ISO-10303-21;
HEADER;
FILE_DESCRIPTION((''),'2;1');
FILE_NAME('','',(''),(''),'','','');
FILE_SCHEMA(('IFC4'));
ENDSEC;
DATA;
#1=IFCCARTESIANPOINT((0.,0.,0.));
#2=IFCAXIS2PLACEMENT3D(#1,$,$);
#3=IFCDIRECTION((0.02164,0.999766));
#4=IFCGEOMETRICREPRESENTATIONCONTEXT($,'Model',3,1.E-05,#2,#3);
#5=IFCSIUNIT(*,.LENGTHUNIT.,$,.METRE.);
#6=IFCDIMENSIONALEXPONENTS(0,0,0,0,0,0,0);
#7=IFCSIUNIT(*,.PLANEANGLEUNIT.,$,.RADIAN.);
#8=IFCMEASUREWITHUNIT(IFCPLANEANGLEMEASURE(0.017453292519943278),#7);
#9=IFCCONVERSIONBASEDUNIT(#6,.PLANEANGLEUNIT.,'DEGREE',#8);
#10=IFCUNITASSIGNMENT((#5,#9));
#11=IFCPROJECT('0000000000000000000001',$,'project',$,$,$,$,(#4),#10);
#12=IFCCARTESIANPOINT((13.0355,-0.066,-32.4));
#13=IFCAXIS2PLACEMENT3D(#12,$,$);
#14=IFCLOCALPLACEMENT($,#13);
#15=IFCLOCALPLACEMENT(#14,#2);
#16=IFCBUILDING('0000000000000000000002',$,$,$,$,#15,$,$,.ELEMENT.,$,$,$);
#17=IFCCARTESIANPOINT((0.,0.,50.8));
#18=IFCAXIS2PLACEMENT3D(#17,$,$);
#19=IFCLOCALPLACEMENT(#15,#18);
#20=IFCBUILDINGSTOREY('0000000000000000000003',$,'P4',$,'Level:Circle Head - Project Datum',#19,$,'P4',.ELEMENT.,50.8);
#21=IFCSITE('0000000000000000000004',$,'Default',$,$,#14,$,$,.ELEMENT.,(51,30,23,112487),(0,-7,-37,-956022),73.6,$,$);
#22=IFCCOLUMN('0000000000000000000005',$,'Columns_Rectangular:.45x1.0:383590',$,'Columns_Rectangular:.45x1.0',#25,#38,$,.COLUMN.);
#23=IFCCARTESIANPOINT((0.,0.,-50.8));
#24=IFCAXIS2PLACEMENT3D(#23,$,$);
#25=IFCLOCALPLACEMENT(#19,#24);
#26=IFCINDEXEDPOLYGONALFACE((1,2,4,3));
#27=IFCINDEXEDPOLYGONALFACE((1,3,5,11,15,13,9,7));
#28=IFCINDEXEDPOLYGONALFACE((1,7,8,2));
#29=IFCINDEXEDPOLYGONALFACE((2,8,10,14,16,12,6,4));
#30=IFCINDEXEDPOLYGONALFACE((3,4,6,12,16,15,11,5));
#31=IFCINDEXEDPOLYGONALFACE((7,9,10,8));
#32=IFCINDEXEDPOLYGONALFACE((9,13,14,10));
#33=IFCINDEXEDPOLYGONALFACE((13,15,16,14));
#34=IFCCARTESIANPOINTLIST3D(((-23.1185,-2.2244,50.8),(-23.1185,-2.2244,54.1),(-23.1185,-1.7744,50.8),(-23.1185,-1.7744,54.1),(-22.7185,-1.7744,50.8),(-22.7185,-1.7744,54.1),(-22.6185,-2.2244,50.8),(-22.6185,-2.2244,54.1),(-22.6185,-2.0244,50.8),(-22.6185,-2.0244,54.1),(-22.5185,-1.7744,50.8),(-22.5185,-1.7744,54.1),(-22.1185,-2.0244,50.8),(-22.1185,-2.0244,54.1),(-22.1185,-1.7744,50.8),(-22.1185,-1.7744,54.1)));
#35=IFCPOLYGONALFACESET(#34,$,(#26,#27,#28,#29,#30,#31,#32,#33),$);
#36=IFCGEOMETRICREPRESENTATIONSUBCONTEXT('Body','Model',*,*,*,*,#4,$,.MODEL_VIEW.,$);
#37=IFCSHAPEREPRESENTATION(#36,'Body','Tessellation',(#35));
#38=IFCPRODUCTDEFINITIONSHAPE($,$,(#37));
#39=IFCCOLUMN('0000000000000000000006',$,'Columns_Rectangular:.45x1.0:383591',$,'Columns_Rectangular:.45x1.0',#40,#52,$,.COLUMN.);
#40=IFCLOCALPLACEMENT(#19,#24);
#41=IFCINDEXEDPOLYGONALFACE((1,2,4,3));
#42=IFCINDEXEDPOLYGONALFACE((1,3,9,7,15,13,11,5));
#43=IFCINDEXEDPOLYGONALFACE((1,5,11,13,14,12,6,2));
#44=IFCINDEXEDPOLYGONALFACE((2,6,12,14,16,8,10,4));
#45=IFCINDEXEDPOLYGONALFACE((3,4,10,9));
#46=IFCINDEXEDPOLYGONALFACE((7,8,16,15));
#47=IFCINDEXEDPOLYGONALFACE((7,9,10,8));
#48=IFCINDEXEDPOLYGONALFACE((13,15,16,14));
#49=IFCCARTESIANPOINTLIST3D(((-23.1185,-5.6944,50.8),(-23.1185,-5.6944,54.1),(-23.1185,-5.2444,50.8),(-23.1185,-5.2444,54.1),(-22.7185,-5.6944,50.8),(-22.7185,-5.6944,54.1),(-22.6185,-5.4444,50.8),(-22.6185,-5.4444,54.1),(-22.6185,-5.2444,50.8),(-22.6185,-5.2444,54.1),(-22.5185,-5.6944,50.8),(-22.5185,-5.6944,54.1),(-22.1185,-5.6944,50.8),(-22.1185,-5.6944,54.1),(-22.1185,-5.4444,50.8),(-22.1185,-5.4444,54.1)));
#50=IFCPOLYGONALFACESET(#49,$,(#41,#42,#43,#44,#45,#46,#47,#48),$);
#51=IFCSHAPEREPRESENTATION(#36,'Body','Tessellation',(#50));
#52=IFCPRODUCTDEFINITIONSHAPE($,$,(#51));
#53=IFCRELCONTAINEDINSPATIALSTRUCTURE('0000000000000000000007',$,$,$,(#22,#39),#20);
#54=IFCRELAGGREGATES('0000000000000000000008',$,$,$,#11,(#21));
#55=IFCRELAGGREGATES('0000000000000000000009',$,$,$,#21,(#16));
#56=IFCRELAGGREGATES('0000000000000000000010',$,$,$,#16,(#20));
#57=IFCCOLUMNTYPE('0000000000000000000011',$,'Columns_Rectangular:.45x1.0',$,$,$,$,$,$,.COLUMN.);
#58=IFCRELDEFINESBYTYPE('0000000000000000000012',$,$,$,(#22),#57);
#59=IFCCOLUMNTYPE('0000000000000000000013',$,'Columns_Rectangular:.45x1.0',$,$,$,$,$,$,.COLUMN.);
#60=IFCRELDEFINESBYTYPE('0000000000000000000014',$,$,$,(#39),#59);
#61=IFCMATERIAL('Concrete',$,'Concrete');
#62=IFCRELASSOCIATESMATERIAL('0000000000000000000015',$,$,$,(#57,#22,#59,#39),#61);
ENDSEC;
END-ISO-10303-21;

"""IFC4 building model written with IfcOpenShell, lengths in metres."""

from ifc_helpers import new_model, entity, si_unit, converted_unit, direction, frame, origin, place, context, subcontext, project, spatial, indexed_curve, outline, extrude, source, transform, mapped, material, type_object, type_shapes, element, save


model = new_model("IFC4")

# Units and contexts
model_context = context("Model", 3, precision=1e-05, world=origin(), true_north=direction((0.02164, 0.999766)))
body_context = subcontext(model_context, "Body", "Model", "MODEL_VIEW")
ifc_project = project(units=[si_unit("LENGTHUNIT", "METRE"), converted_unit("PLANEANGLEUNIT", "DEGREE", entity("IfcPlaneAngleMeasure", 0.017453292519943278), si_unit("PLANEANGLEUNIT", "RADIAN"), dimensions=[0, 0, 0, 0, 0, 0, 0])], contexts=[model_context])

# Site, building, storey
site_placement = place(None, frame((13.0355, -0.066, -32.4)))
site = spatial("IfcSite", under=ifc_project, at=site_placement, Name="Default", CompositionType="ELEMENT", RefLatitude=(51, 30, 23, 112487), RefLongitude=(0, -7, -37, -956022), RefElevation=73.6)
building_placement = place(site_placement, origin())
building = spatial("IfcBuilding", under=site, at=building_placement, CompositionType="ELEMENT")
storey_placement = place(building_placement, frame((0.0, 0.0, 50.8)))
storey = spatial("IfcBuildingStorey", under=building, at=storey_placement, Name="P4", ObjectType="Level:Circle Head - Project Datum", LongName="P4", CompositionType="ELEMENT", Elevation=50.8)

# Columns
ifc_material = material(Name="Concrete", Category="Concrete")
column_type_1 = type_object("IfcColumnType", Name="Columns_Rectangular:.45x1.0", PredefinedType="COLUMN", material=ifc_material)
shared_shape_1 = source(origin(), body_context, "Body", "SweptSolid", [
    extrude(outline(indexed_curve([(-0.5, -0.275), (0.0, -0.275), (0.0, -0.075), (0.5, -0.075), (0.5, 0.175), (0.1, 0.175), (-0.1, 0.175), (-0.5, 0.175), (-0.5, -0.275)], self_intersect=False)), frame((-22.6185, -1.9494, 50.8)), (0.0, 0.0, 1.0), 3.3),
])
type_shapes(column_type_1, [shared_shape_1])
column_1_placement = place(storey_placement, frame((0.0, 0.0, -50.8)))
element("IfcColumn", 1, at=column_1_placement, inside=storey, type_object=column_type_1, material=ifc_material, Name="Columns_Rectangular:.45x1.0:383590", ObjectType="Columns_Rectangular:.45x1.0", PredefinedType="COLUMN", context=body_context, shape_type="MappedRepresentation", body=[
    mapped(shared_shape_1, transform((0.0, 0.0, 0.0), scale=1.0)),
])
column_type_2 = type_object("IfcColumnType", Name="Columns_Rectangular:.45x1.0", PredefinedType="COLUMN", material=ifc_material)
shared_shape_2 = source(origin(), body_context, "Body", "SweptSolid", [
    extrude(outline(indexed_curve([(-0.175, -0.5), (0.075, -0.5), (0.075, 0.0), (0.275, 0.0), (0.275, 0.5), (-0.175, 0.5), (-0.175, 0.1), (-0.175, -0.1), (-0.175, -0.5)], self_intersect=False)), frame((-22.6185, -5.5194, 50.8), z_axis=(0.0, 0.0, 1.0), x_axis=(0.0, 1.0, 0.0)), (0.0, 0.0, 1.0), 3.3),
])
type_shapes(column_type_2, [shared_shape_2])
column_2_placement = place(storey_placement, frame((0.0, 0.0, -50.8)))
element("IfcColumn", 2, at=column_2_placement, inside=storey, type_object=column_type_2, material=ifc_material, Name="Columns_Rectangular:.45x1.0:383591", ObjectType="Columns_Rectangular:.45x1.0", PredefinedType="COLUMN", context=body_context, shape_type="MappedRepresentation", body=[
    mapped(shared_shape_2, transform((0.0, 0.0, 0.0), scale=1.0)),
])

save(model, "model.ifc")
